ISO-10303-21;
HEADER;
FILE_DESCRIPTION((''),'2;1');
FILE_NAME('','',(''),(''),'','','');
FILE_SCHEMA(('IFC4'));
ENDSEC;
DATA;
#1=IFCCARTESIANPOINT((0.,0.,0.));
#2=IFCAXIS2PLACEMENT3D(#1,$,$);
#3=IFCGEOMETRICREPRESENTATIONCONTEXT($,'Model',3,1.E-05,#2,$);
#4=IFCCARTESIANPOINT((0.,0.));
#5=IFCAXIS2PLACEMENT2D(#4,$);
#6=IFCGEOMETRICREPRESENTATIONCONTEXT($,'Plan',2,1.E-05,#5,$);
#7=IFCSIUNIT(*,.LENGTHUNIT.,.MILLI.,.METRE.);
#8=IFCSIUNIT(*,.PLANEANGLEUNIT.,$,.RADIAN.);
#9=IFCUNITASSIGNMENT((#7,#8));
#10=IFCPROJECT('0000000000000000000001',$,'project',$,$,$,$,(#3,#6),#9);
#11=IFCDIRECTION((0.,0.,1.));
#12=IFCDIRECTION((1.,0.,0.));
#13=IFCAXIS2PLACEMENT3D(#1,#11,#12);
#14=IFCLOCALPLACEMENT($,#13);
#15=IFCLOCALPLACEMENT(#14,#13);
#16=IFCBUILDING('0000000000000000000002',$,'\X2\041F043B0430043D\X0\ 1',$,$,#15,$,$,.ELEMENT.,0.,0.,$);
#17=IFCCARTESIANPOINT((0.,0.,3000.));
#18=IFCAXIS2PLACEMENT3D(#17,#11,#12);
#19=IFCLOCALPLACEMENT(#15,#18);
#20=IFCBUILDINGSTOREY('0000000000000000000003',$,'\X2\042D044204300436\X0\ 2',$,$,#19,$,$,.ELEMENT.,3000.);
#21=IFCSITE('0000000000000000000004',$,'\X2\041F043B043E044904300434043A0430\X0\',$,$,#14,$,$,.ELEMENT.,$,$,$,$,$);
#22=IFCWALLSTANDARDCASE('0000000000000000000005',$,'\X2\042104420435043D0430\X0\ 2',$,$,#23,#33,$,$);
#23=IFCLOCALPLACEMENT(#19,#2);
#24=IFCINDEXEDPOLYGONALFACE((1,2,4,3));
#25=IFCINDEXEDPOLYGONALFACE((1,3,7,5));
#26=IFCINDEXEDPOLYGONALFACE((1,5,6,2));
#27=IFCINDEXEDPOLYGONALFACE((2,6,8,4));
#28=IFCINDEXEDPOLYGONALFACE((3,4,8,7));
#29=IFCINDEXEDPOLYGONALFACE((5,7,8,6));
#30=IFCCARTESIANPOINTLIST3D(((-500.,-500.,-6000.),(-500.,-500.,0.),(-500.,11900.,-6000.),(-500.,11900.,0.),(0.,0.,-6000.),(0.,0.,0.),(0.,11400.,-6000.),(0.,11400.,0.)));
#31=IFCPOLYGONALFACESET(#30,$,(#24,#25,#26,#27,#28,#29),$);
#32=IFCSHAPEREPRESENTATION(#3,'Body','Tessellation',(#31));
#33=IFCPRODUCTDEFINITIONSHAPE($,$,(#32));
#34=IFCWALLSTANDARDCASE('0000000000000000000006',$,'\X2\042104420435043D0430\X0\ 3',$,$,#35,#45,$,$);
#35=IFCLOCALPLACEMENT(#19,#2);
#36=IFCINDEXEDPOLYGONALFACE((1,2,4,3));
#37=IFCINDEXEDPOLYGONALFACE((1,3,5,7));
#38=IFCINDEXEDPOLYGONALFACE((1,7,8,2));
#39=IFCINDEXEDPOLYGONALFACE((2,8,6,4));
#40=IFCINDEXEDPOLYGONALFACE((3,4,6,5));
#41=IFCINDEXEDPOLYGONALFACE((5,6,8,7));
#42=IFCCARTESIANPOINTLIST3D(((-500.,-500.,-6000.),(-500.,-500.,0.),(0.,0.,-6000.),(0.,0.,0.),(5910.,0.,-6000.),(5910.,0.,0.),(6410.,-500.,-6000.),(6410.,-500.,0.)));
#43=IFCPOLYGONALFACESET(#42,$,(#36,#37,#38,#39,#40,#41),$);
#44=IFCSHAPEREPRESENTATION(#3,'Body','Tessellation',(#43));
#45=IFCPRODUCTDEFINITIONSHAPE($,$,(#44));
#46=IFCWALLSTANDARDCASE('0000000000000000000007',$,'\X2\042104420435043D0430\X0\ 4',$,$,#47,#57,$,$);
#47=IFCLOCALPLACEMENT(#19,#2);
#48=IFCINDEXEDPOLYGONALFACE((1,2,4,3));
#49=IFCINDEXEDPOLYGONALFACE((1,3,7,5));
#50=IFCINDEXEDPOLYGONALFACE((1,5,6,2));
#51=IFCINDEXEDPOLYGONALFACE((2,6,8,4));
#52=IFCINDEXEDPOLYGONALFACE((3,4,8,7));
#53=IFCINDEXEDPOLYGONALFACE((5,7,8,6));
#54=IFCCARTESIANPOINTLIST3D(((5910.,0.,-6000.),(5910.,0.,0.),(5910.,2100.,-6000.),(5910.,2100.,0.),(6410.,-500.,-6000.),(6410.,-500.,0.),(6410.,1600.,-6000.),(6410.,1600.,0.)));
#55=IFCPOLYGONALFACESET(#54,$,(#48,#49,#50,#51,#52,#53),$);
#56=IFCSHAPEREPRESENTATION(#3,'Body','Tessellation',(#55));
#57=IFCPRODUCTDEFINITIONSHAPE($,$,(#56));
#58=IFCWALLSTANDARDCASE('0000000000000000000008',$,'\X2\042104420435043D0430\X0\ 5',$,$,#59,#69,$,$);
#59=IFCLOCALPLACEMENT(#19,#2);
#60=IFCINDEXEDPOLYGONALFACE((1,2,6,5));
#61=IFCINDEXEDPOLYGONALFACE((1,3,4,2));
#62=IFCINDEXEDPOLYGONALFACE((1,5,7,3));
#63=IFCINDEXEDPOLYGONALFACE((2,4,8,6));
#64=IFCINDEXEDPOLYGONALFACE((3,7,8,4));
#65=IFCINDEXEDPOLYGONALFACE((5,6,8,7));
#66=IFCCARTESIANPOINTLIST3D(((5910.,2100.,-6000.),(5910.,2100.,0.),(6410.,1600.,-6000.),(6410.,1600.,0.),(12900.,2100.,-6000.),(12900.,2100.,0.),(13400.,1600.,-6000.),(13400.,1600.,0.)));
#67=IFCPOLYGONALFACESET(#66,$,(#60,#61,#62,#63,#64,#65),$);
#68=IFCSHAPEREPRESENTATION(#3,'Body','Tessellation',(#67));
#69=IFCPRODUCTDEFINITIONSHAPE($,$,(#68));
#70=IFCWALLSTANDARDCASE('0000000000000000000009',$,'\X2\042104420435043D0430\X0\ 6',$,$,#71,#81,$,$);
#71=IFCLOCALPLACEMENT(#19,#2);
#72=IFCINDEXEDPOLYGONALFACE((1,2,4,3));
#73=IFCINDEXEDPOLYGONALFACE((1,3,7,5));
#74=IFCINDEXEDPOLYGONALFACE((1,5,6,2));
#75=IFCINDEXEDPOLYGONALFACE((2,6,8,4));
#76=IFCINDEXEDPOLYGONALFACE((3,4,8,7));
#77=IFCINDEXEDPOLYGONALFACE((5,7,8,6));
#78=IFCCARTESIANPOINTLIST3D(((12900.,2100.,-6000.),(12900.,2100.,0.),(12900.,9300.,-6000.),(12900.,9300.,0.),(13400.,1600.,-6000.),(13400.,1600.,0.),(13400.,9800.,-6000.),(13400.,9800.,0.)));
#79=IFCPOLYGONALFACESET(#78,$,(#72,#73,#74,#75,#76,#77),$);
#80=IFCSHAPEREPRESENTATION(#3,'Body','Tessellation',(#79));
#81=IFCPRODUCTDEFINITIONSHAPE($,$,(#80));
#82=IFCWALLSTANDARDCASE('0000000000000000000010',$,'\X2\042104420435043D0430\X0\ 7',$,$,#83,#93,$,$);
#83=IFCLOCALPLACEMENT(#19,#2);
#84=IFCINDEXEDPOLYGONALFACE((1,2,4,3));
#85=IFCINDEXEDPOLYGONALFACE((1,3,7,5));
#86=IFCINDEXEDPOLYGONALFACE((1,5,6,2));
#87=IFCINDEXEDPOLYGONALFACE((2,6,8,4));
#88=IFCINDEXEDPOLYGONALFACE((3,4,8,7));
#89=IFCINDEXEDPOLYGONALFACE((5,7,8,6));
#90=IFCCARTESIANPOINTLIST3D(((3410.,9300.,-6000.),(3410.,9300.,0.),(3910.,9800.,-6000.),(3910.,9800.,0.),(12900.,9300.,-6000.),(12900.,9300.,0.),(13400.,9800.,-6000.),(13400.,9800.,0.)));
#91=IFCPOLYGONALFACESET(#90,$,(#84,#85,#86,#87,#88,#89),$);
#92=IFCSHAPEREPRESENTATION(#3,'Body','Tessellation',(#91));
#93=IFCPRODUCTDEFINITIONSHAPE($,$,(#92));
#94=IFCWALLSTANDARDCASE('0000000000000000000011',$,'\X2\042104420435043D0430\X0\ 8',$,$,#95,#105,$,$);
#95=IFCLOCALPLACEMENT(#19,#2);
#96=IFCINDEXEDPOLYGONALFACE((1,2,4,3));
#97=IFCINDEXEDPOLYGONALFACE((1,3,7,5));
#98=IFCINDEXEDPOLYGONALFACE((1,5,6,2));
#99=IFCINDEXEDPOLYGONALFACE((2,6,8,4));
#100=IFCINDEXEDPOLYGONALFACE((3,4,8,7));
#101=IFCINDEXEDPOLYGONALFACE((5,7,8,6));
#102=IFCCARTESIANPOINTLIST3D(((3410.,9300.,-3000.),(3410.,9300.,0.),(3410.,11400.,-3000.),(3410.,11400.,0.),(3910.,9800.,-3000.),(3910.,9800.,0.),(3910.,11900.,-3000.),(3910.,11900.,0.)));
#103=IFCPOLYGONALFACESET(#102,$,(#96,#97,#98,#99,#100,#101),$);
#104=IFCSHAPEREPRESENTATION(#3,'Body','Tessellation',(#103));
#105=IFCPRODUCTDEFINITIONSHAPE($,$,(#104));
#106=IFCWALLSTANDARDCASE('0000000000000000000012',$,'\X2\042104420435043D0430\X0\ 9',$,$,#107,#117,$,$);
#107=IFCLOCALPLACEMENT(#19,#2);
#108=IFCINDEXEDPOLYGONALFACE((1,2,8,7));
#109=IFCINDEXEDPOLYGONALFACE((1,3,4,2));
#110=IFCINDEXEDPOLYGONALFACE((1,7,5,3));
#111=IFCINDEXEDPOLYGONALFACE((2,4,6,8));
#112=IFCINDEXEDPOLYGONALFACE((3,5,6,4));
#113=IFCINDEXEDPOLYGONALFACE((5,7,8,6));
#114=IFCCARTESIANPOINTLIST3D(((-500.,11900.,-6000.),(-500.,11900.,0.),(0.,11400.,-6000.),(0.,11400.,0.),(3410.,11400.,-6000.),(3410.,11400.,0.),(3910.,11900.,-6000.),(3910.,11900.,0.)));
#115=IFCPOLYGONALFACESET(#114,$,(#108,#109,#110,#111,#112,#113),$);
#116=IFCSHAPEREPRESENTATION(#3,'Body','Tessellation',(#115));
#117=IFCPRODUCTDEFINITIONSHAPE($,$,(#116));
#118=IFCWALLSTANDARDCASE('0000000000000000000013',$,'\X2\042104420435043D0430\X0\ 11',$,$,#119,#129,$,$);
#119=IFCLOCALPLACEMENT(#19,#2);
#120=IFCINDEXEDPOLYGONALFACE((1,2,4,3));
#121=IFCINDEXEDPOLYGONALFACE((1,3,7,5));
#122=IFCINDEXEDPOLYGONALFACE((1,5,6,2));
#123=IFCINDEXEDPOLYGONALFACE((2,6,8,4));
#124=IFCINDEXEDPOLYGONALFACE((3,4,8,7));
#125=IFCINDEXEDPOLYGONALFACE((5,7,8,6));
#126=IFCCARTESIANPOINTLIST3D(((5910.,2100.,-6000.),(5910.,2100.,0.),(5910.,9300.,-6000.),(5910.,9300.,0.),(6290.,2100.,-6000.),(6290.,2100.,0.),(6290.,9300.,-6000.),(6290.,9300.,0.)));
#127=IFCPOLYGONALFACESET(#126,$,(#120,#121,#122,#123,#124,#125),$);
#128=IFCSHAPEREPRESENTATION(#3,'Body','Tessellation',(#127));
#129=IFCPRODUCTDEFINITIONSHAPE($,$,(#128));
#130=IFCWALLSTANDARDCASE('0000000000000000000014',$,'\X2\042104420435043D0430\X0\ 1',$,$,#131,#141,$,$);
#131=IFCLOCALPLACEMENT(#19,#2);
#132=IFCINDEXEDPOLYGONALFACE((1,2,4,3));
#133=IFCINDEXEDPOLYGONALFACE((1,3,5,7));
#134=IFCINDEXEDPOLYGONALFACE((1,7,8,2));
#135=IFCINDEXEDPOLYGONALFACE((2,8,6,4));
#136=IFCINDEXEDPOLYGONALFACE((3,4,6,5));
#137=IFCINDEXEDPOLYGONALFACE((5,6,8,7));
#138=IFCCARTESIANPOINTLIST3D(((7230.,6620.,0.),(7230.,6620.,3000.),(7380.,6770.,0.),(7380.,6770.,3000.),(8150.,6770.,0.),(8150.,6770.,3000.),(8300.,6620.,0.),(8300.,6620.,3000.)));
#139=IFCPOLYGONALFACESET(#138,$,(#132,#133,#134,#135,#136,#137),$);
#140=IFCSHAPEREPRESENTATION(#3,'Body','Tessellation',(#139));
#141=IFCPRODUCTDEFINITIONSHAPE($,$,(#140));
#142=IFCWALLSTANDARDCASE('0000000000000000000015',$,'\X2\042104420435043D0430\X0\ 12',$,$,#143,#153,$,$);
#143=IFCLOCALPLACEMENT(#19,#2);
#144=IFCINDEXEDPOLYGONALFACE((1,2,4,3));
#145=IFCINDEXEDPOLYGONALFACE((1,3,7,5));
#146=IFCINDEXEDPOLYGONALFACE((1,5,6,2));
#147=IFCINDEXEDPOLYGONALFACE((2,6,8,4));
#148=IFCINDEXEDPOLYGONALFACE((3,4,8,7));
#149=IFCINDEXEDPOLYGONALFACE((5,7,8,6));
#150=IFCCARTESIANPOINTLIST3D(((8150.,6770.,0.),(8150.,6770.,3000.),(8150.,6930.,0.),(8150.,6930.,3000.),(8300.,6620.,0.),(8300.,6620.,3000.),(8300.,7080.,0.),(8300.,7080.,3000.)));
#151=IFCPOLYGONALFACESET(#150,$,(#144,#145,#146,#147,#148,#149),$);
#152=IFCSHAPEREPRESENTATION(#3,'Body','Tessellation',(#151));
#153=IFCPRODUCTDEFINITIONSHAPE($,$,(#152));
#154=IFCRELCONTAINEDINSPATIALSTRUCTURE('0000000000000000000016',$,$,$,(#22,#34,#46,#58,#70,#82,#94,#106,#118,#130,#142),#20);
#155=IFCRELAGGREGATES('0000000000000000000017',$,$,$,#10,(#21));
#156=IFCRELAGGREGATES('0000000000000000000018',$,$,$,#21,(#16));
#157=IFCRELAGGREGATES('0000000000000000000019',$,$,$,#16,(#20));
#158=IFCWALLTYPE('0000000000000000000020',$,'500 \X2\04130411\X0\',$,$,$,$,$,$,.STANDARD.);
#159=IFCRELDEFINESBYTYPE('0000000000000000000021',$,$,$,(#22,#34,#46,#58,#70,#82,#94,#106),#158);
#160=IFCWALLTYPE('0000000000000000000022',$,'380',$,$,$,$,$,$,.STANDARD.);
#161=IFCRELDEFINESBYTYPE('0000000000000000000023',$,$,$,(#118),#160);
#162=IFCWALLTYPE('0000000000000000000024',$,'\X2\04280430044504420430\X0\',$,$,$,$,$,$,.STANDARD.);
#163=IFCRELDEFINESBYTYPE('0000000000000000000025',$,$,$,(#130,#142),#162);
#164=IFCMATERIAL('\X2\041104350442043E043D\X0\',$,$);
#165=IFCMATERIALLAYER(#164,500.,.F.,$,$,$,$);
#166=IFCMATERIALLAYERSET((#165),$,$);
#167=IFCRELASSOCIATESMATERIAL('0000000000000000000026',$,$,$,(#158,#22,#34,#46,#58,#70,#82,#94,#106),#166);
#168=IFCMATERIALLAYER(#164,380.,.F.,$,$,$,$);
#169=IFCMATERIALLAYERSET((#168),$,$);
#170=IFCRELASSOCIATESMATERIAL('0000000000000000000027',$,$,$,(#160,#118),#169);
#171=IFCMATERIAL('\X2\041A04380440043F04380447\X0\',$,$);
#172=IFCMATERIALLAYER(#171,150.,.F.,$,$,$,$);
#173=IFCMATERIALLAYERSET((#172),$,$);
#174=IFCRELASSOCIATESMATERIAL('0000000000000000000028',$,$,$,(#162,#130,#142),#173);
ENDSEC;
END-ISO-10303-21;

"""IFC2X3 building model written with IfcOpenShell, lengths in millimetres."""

from ifc_helpers import new_model, si_unit, frame, origin, origin_with_axes, origin_2d, place, context, project, spatial, polyline, segment, composite_curve, outline, extrude, material, layer, layer_set, layer_usage, type_object, element, save


model = new_model("IFC2X3")

# Units and contexts
model_context = context("Model", 3, precision=1e-05, world=origin())
plan_context = context("Plan", 2, precision=1e-05, world=origin_2d())
ifc_project = project(units=[si_unit("LENGTHUNIT", "METRE", prefix="MILLI"), si_unit("PLANEANGLEUNIT", "RADIAN")], contexts=[model_context, plan_context])

# Site, building, storey
site_placement = place(None, origin_with_axes())
site = spatial("IfcSite", under=ifc_project, at=site_placement, Name="Площадка", CompositionType="ELEMENT")
building_placement = place(site_placement, origin_with_axes())
building = spatial("IfcBuilding", under=site, at=building_placement, Name="План 1", CompositionType="ELEMENT", ElevationOfRefHeight=0.0, ElevationOfTerrain=0.0)
storey_placement = place(building_placement, frame((0.0, 0.0, 3000.0), z_axis=(0.0, 0.0, 1.0), x_axis=(1.0, 0.0, 0.0)))
storey = spatial("IfcBuildingStorey", under=building, at=storey_placement, Name="Этаж 2", CompositionType="ELEMENT", Elevation=3000.0)

# Walls
ifc_material_1 = material(Name="Бетон")
ifc_layer_1 = layer(ifc_material_1, 500.0, ventilated=False)
ifc_layer_set_1 = layer_set([ifc_layer_1])
ifc_layer_usage_1 = layer_usage(ifc_layer_set_1, "AXIS2", "POSITIVE", 0.0)
wall_type_1 = type_object("IfcWallType", Name="500 ГБ", PredefinedType="STANDARD", material=ifc_layer_set_1)
wall_1_placement = place(storey_placement, frame((-500.0, 11900.0, -6000.0), z_axis=(0.0, 0.0, 1.0), x_axis=(0.0, -1.0, 0.0)))
element("IfcWallStandardCase", 1, at=wall_1_placement, inside=storey, type_object=wall_type_1, material=ifc_layer_usage_1, Name="Стена 2", context=model_context, shape_type="SweptSolid", body=[
    extrude(outline(composite_curve([segment(polyline([(500.0, 500.0), (0.0, 0.0)]), True, "CONTINUOUS"), segment(polyline([(0.0, 0.0), (12400.0, 0.0)]), True, "CONTINUOUS"), segment(polyline([(12400.0, 0.0), (11900.0, 500.0)]), True, "CONTINUOUS"), segment(polyline([(11900.0, 500.0), (500.0, 500.0)]), True, "CONTINUOUS")], self_intersect=False)), origin_with_axes(), (0.0, 0.0, 1.0), 6000.0),
])
ifc_layer_usage_2 = layer_usage(ifc_layer_set_1, "AXIS2", "POSITIVE", 0.0)
wall_2_placement = place(storey_placement, frame((-500.0, -500.0, -6000.0), z_axis=(0.0, 0.0, 1.0), x_axis=(1.0, 0.0, 0.0)))
element("IfcWallStandardCase", 2, at=wall_2_placement, inside=storey, type_object=wall_type_1, material=ifc_layer_usage_2, Name="Стена 3", context=model_context, shape_type="SweptSolid", body=[
    extrude(outline(composite_curve([segment(polyline([(500.0, 500.0), (0.0, 0.0)]), True, "CONTINUOUS"), segment(polyline([(0.0, 0.0), (6910.0, 0.0)]), True, "CONTINUOUS"), segment(polyline([(6910.0, 0.0), (6410.0, 500.0)]), True, "CONTINUOUS"), segment(polyline([(6410.0, 500.0), (500.0, 500.0)]), True, "CONTINUOUS")], self_intersect=False)), origin_with_axes(), (0.0, 0.0, 1.0), 6000.0),
])
ifc_layer_usage_3 = layer_usage(ifc_layer_set_1, "AXIS2", "POSITIVE", 0.0)
wall_3_placement = place(storey_placement, frame((6410.0, -500.0, -6000.0), z_axis=(0.0, 0.0, 1.0), x_axis=(0.0, 1.0, 0.0)))
element("IfcWallStandardCase", 3, at=wall_3_placement, inside=storey, type_object=wall_type_1, material=ifc_layer_usage_3, Name="Стена 4", context=model_context, shape_type="SweptSolid", body=[
    extrude(outline(composite_curve([segment(polyline([(500.0, 500.0), (0.0, 0.0)]), True, "CONTINUOUS"), segment(polyline([(0.0, 0.0), (2100.0, 0.0)]), True, "CONTINUOUS"), segment(polyline([(2100.0, 0.0), (2600.0, 500.0)]), True, "CONTINUOUS"), segment(polyline([(2600.0, 500.0), (500.0, 500.0)]), True, "CONTINUOUS")], self_intersect=False)), origin_with_axes(), (0.0, 0.0, 1.0), 6000.0),
])
ifc_layer_usage_4 = layer_usage(ifc_layer_set_1, "AXIS2", "POSITIVE", 0.0)
wall_4_placement = place(storey_placement, frame((6410.0, 1600.0, -6000.0), z_axis=(0.0, 0.0, 1.0), x_axis=(1.0, 0.0, 0.0)))
element("IfcWallStandardCase", 4, at=wall_4_placement, inside=storey, type_object=wall_type_1, material=ifc_layer_usage_4, Name="Стена 5", context=model_context, shape_type="SweptSolid", body=[
    extrude(outline(composite_curve([segment(polyline([(-500.0, 500.0), (0.0, 0.0)]), True, "CONTINUOUS"), segment(polyline([(0.0, 0.0), (6990.0, 0.0)]), True, "CONTINUOUS"), segment(polyline([(6990.0, 0.0), (6490.0, 500.0)]), True, "CONTINUOUS"), segment(polyline([(6490.0, 500.0), (-500.0, 500.0)]), True, "CONTINUOUS")], self_intersect=False)), origin_with_axes(), (0.0, 0.0, 1.0), 6000.0),
])
ifc_layer_usage_5 = layer_usage(ifc_layer_set_1, "AXIS2", "POSITIVE", 0.0)
wall_5_placement = place(storey_placement, frame((13400.0, 1600.0, -6000.0), z_axis=(0.0, 0.0, 1.0), x_axis=(0.0, 1.0, 0.0)))
element("IfcWallStandardCase", 5, at=wall_5_placement, inside=storey, type_object=wall_type_1, material=ifc_layer_usage_5, Name="Стена 6", context=model_context, shape_type="SweptSolid", body=[
    extrude(outline(composite_curve([segment(polyline([(500.0, 500.0), (0.0, 0.0)]), True, "CONTINUOUS"), segment(polyline([(0.0, 0.0), (8200.0, 0.0)]), True, "CONTINUOUS"), segment(polyline([(8200.0, 0.0), (7700.0, 500.0)]), True, "CONTINUOUS"), segment(polyline([(7700.0, 500.0), (500.0, 500.0)]), True, "CONTINUOUS")], self_intersect=False)), origin_with_axes(), (0.0, 0.0, 1.0), 6000.0),
])
ifc_layer_usage_6 = layer_usage(ifc_layer_set_1, "AXIS2", "POSITIVE", 0.0)
wall_6_placement = place(storey_placement, frame((13400.0, 9800.0, -6000.0), z_axis=(0.0, 0.0, 1.0), x_axis=(-1.0, 0.0, 0.0)))
element("IfcWallStandardCase", 6, at=wall_6_placement, inside=storey, type_object=wall_type_1, material=ifc_layer_usage_6, Name="Стена 7", context=model_context, shape_type="SweptSolid", body=[
    extrude(outline(composite_curve([segment(polyline([(500.0, 500.0), (0.0, 0.0)]), True, "CONTINUOUS"), segment(polyline([(0.0, 0.0), (9490.0, 0.0)]), True, "CONTINUOUS"), segment(polyline([(9490.0, 0.0), (9990.0, 500.0)]), True, "CONTINUOUS"), segment(polyline([(9990.0, 500.0), (500.0, 500.0)]), True, "CONTINUOUS")], self_intersect=False)), origin_with_axes(), (0.0, 0.0, 1.0), 6000.0),
])
ifc_layer_usage_7 = layer_usage(ifc_layer_set_1, "AXIS2", "POSITIVE", 0.0)
wall_7_placement = place(storey_placement, frame((3910.0, 9800.0, -3000.0), z_axis=(0.0, 0.0, 1.0), x_axis=(0.0, 1.0, 0.0)))
element("IfcWallStandardCase", 7, at=wall_7_placement, inside=storey, type_object=wall_type_1, material=ifc_layer_usage_7, Name="Стена 8", context=model_context, shape_type="SweptSolid", body=[
    extrude(outline(composite_curve([segment(polyline([(-500.0, 500.0), (0.0, 0.0)]), True, "CONTINUOUS"), segment(polyline([(0.0, 0.0), (2100.0, 0.0)]), True, "CONTINUOUS"), segment(polyline([(2100.0, 0.0), (1600.0, 500.0)]), True, "CONTINUOUS"), segment(polyline([(1600.0, 500.0), (-500.0, 500.0)]), True, "CONTINUOUS")], self_intersect=False)), origin_with_axes(), (0.0, 0.0, 1.0), 3000.0),
])
ifc_layer_usage_8 = layer_usage(ifc_layer_set_1, "AXIS2", "POSITIVE", 0.0)
wall_8_placement = place(storey_placement, frame((3910.0, 11900.0, -6000.0), z_axis=(0.0, 0.0, 1.0), x_axis=(-1.0, 0.0, 0.0)))
element("IfcWallStandardCase", 8, at=wall_8_placement, inside=storey, type_object=wall_type_1, material=ifc_layer_usage_8, Name="Стена 9", context=model_context, shape_type="SweptSolid", body=[
    extrude(outline(composite_curve([segment(polyline([(500.0, 500.0), (0.0, 0.0)]), True, "CONTINUOUS"), segment(polyline([(0.0, 0.0), (4410.0, 0.0)]), True, "CONTINUOUS"), segment(polyline([(4410.0, 0.0), (3910.0, 500.0)]), True, "CONTINUOUS"), segment(polyline([(3910.0, 500.0), (500.0, 500.0)]), True, "CONTINUOUS")], self_intersect=False)), origin_with_axes(), (0.0, 0.0, 1.0), 6000.0),
])
ifc_layer_2 = layer(ifc_material_1, 380.0, ventilated=False)
ifc_layer_set_2 = layer_set([ifc_layer_2])
wall_type_2 = type_object("IfcWallType", Name="380", PredefinedType="STANDARD", material=ifc_layer_set_2)
ifc_layer_usage_9 = layer_usage(ifc_layer_set_2, "AXIS2", "POSITIVE", -190.0)
wall_9_placement = place(storey_placement, frame((6100.0, 2100.0, -6000.0), z_axis=(0.0, 0.0, 1.0), x_axis=(0.0, 1.0, 0.0)))
element("IfcWallStandardCase", 9, at=wall_9_placement, inside=storey, type_object=wall_type_2, material=ifc_layer_usage_9, Name="Стена 11", context=model_context, shape_type="SweptSolid", body=[
    extrude(outline(composite_curve([segment(polyline([(0.0, 190.0), (0.0, -190.0)]), True, "CONTINUOUS"), segment(polyline([(0.0, -190.0), (7200.0, -190.0)]), True, "CONTINUOUS"), segment(polyline([(7200.0, -190.0), (7200.0, 190.0)]), True, "CONTINUOUS"), segment(polyline([(7200.0, 190.0), (0.0, 190.0)]), True, "CONTINUOUS")], self_intersect=False)), origin_with_axes(), (0.0, 0.0, 1.0), 6000.0),
])
ifc_material_2 = material(Name="Кирпич")
ifc_layer_3 = layer(ifc_material_2, 150.0, ventilated=False)
ifc_layer_set_3 = layer_set([ifc_layer_3])
ifc_layer_usage_10 = layer_usage(ifc_layer_set_3, "AXIS2", "POSITIVE", 0.0)
wall_type_3 = type_object("IfcWallType", Name="Шахта", PredefinedType="STANDARD", material=ifc_layer_set_3)
wall_10_placement = place(storey_placement, frame((7230.0, 6620.0, 0.0), z_axis=(0.0, 0.0, 1.0), x_axis=(1.0, 0.0, 0.0)))
element("IfcWallStandardCase", 10, at=wall_10_placement, inside=storey, type_object=wall_type_3, material=ifc_layer_usage_10, Name="Стена 1", context=model_context, shape_type="SweptSolid", body=[
    extrude(outline(composite_curve([segment(polyline([(150.0, 150.0), (0.0, 0.0)]), True, "CONTINUOUS"), segment(polyline([(0.0, 0.0), (1070.0, 0.0)]), True, "CONTINUOUS"), segment(polyline([(1070.0, 0.0), (920.0, 150.0)]), True, "CONTINUOUS"), segment(polyline([(920.0, 150.0), (150.0, 150.0)]), True, "CONTINUOUS")], self_intersect=False)), origin_with_axes(), (0.0, 0.0, 1.0), 3000.0),
])
ifc_layer_usage_11 = layer_usage(ifc_layer_set_3, "AXIS2", "POSITIVE", 0.0)
wall_11_placement = place(storey_placement, frame((8300.0, 6620.0, 0.0), z_axis=(0.0, 0.0, 1.0), x_axis=(0.0, 1.0, 0.0)))
element("IfcWallStandardCase", 11, at=wall_11_placement, inside=storey, type_object=wall_type_3, material=ifc_layer_usage_11, Name="Стена 12", context=model_context, shape_type="SweptSolid", body=[
    extrude(outline(composite_curve([segment(polyline([(150.0, 150.0), (0.0, 0.0)]), True, "CONTINUOUS"), segment(polyline([(0.0, 0.0), (460.0, 0.0)]), True, "CONTINUOUS"), segment(polyline([(460.0, 0.0), (310.0, 150.0)]), True, "CONTINUOUS"), segment(polyline([(310.0, 150.0), (150.0, 150.0)]), True, "CONTINUOUS")], self_intersect=False)), origin_with_axes(), (0.0, 0.0, 1.0), 3000.0),
])

save(model, "model.ifc")
